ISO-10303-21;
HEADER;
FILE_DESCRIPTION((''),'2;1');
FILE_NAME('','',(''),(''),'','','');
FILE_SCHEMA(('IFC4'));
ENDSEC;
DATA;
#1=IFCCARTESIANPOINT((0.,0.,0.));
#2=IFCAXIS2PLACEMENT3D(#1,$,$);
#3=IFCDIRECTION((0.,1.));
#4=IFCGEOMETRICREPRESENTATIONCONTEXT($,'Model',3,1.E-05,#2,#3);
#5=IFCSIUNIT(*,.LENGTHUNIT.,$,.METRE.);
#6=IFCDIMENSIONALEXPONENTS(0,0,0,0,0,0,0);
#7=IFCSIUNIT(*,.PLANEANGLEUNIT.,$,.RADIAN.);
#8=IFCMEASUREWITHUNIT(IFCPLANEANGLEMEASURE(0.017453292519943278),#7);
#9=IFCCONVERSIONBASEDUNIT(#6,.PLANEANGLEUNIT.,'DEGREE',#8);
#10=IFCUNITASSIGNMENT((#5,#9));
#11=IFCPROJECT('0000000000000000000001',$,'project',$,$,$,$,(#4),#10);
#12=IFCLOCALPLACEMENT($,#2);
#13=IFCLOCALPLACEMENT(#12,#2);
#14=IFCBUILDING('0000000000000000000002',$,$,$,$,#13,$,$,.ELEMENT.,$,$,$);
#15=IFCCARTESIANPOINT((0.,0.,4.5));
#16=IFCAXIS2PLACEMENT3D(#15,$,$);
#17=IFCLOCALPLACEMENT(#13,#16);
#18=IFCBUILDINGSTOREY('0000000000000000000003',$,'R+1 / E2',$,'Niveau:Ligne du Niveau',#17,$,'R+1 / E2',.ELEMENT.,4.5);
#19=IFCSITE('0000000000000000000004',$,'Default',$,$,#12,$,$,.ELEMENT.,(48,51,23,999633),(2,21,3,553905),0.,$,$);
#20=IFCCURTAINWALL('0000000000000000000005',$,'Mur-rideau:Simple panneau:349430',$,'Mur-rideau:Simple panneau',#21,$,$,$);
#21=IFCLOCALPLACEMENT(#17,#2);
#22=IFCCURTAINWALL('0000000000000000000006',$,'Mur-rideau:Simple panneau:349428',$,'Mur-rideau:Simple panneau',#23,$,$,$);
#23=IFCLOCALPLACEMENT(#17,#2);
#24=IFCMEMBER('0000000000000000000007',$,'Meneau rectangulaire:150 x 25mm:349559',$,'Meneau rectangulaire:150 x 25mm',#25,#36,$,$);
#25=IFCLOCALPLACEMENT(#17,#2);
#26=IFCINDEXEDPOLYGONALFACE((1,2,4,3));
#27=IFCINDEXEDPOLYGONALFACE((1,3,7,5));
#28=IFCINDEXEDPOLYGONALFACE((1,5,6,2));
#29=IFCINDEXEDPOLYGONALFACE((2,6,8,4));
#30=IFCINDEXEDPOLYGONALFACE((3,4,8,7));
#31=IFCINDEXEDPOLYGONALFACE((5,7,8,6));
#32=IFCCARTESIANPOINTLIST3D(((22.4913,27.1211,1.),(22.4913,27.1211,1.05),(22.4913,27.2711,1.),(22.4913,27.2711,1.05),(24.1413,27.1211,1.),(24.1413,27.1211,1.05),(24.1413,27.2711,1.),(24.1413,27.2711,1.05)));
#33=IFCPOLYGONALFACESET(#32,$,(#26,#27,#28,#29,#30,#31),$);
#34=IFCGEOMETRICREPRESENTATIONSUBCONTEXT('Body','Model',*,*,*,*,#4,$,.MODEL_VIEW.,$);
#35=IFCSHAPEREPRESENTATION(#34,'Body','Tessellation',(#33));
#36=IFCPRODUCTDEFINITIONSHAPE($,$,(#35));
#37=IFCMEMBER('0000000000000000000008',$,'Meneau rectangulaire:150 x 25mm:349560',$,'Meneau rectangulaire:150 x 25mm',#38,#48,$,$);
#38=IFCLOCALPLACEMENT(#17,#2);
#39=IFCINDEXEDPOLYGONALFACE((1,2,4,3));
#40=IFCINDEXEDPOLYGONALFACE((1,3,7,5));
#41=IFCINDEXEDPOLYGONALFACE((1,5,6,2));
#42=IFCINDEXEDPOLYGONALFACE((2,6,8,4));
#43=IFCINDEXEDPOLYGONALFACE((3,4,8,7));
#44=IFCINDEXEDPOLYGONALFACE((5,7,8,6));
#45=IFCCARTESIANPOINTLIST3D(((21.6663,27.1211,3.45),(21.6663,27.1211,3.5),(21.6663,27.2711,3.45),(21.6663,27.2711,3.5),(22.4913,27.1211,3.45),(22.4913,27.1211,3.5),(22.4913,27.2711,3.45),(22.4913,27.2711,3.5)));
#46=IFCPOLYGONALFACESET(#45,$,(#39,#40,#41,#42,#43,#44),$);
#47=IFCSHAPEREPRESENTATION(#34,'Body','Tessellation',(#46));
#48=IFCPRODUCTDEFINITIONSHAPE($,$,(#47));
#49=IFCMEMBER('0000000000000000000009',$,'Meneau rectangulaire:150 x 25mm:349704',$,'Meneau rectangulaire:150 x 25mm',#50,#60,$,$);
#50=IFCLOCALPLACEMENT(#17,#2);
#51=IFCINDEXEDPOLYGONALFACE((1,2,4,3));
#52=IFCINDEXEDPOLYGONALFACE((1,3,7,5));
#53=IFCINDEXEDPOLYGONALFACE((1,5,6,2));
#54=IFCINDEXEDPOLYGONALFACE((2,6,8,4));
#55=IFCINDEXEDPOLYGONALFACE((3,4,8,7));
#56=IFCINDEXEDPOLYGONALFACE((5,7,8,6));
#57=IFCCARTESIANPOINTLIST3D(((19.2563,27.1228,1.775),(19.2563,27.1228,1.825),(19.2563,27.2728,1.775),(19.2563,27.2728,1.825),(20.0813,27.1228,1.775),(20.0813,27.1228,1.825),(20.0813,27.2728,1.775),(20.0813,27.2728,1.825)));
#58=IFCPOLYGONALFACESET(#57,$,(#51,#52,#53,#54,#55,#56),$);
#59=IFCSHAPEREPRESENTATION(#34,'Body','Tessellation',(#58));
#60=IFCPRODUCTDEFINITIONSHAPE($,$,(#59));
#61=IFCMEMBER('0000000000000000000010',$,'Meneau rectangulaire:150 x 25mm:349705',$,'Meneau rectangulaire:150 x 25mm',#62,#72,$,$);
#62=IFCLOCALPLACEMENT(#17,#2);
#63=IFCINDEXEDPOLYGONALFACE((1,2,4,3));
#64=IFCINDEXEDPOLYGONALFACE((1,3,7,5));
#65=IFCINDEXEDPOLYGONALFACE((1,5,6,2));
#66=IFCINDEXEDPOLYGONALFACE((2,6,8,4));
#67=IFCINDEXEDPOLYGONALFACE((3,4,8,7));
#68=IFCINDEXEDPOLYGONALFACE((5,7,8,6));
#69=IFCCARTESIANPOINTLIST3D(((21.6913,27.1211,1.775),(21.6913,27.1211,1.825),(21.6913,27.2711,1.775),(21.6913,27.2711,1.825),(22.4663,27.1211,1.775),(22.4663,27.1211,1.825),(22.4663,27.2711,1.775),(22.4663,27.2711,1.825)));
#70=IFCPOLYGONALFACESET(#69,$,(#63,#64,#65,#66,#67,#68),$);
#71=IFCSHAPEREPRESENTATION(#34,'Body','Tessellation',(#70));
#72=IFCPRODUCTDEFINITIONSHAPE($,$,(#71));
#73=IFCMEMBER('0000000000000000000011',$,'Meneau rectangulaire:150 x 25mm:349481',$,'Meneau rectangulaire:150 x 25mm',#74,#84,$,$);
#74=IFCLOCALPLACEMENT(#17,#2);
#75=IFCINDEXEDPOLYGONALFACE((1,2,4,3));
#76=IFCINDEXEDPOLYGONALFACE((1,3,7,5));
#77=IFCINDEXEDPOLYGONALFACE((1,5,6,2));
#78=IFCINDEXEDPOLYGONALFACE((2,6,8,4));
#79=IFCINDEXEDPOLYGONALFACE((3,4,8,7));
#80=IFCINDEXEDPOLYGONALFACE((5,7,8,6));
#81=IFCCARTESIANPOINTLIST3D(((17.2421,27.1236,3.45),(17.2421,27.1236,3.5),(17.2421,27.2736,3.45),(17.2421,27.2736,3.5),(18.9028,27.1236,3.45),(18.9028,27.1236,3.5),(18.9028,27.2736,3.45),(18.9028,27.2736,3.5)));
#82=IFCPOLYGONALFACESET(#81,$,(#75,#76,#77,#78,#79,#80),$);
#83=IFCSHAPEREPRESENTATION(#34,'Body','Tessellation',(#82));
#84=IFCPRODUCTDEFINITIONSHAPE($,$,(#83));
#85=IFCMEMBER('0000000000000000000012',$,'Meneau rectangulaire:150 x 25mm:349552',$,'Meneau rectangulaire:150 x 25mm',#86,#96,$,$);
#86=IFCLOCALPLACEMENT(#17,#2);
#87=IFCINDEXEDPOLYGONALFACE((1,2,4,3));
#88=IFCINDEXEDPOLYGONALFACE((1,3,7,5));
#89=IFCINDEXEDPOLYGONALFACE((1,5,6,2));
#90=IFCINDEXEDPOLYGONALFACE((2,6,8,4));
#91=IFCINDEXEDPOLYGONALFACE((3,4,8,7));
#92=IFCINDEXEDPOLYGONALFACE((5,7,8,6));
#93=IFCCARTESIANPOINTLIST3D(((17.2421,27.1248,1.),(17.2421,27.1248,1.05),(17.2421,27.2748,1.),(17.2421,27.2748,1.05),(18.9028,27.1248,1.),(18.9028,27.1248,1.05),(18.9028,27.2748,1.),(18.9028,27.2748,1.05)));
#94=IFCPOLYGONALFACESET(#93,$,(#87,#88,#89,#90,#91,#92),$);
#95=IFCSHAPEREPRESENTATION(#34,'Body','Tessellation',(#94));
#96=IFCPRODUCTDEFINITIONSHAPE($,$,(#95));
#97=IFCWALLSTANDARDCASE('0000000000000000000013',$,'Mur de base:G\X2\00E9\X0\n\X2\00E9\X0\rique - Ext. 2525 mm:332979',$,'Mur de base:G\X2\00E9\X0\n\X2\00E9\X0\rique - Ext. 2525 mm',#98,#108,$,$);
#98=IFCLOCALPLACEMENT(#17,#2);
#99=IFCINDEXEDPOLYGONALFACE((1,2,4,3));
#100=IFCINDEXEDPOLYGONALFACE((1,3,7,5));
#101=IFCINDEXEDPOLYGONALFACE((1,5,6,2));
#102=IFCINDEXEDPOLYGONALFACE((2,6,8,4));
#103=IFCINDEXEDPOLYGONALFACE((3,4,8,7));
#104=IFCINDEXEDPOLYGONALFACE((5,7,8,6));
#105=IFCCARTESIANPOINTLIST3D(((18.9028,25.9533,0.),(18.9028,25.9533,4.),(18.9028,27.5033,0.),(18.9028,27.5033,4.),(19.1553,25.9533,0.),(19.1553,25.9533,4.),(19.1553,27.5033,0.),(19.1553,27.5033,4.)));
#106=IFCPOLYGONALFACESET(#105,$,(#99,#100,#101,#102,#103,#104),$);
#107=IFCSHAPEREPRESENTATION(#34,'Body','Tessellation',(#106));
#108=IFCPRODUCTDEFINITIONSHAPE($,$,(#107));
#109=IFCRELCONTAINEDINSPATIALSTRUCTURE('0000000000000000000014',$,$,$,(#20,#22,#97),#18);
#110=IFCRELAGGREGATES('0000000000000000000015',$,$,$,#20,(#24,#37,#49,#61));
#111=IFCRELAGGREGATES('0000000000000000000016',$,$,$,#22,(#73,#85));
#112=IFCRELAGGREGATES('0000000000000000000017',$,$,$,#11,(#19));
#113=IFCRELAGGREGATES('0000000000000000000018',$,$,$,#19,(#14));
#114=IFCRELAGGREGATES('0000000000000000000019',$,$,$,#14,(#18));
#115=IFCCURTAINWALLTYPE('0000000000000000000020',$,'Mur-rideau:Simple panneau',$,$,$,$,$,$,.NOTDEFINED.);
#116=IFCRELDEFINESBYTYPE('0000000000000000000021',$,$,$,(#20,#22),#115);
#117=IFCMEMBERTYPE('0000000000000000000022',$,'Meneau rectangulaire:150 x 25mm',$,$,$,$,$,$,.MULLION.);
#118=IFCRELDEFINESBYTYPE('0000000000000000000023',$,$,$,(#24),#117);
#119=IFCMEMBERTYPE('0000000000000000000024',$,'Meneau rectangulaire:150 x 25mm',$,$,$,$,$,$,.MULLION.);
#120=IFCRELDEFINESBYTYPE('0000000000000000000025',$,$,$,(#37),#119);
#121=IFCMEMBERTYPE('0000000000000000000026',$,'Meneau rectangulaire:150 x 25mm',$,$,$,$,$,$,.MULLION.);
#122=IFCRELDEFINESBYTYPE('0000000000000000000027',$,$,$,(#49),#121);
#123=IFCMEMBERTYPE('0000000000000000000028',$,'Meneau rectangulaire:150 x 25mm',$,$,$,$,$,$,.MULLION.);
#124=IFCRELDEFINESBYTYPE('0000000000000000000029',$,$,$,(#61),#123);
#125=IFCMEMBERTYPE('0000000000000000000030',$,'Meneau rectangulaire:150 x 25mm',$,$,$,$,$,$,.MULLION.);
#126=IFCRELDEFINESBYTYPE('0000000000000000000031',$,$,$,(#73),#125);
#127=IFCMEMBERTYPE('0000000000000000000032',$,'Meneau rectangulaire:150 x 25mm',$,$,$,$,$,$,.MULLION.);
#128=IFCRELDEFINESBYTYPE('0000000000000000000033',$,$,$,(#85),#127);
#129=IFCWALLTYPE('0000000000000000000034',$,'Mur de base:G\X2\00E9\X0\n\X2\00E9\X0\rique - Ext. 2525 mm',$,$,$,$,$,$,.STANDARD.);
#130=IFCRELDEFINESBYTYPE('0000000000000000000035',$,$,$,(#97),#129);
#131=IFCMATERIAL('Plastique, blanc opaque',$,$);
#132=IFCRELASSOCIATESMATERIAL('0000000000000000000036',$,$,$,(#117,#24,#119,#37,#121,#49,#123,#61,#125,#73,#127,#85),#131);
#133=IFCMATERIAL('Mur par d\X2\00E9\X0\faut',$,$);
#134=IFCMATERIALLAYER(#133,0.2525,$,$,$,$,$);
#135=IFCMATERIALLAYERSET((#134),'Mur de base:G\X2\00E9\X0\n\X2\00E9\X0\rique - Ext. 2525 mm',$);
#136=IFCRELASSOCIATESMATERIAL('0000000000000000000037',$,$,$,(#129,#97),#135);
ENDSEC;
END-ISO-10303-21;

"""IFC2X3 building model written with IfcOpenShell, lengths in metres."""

from ifc_helpers import new_model, entity, si_unit, converted_unit, direction, frame, frame_2d, origin, origin_2d_with_axis, place, context, subcontext, project, spatial, rectangle, extrude, source, transform, mapped, material, layer, layer_set, layer_usage, type_object, type_shapes, element, aggregate, save


model = new_model("IFC2X3")

# Units and contexts
model_context = context("Model", 3, precision=1e-05, world=origin(), true_north=direction((0.0, 1.0)))
body_context = subcontext(model_context, "Body", "Model", "MODEL_VIEW")
ifc_project = project(units=[si_unit("LENGTHUNIT", "METRE"), converted_unit("PLANEANGLEUNIT", "DEGREE", entity("IfcPlaneAngleMeasure", 0.017453292519943278), si_unit("PLANEANGLEUNIT", "RADIAN"), dimensions=[0, 0, 0, 0, 0, 0, 0])], contexts=[model_context])

# Site, building, storey
site_placement = place(None, origin())
site = spatial("IfcSite", under=ifc_project, at=site_placement, Name="Default", CompositionType="ELEMENT", RefLatitude=(48, 51, 23, 999633), RefLongitude=(2, 21, 3, 553905), RefElevation=0.0)
building_placement = place(site_placement, origin())
building = spatial("IfcBuilding", under=site, at=building_placement, CompositionType="ELEMENT")
storey_placement = place(building_placement, frame((0.0, 0.0, 4.5)))
storey = spatial("IfcBuildingStorey", under=building, at=storey_placement, Name="R+1 / E2", ObjectType="Niveau:Ligne du Niveau", LongName="R+1 / E2", CompositionType="ELEMENT", Elevation=4.5)

# Curtain wall
curtain_wall_type = type_object("IfcCurtainWallType", Name="Mur-rideau:Simple panneau", PredefinedType="NOTDEFINED")
curtain_wall_1_placement = place(storey_placement, frame((0.0, 0.0, -4.5)))
curtain_wall_1 = element("IfcCurtainWall", 1, at=curtain_wall_1_placement, inside=storey, type_object=curtain_wall_type, Name="Mur-rideau:Simple panneau:349430", ObjectType="Mur-rideau:Simple panneau")
ifc_material_1 = material(Name="Plastique, blanc opaque")

# Curtain wall
curtain_wall_2_placement = place(storey_placement, frame((0.0, 0.0, -4.5)))
curtain_wall_2 = element("IfcCurtainWall", 2, at=curtain_wall_2_placement, inside=storey, type_object=curtain_wall_type, Name="Mur-rideau:Simple panneau:349428", ObjectType="Mur-rideau:Simple panneau")

# Members
member_type_1 = type_object("IfcMemberType", Name="Meneau rectangulaire:150 x 25mm", PredefinedType="MULLION", material=ifc_material_1)
shared_shape_1 = source(origin(), body_context, "Body", "SweptSolid", [
    extrude(rectangle(XDim=0.05, YDim=0.15, at=origin_2d_with_axis()), frame((-0.025, 0.0, -1.65), z_axis=(0.0, 0.0, 1.0), x_axis=(-1.0, 0.0, 0.0)), (0.0, 0.0, 1.0), 1.65),
])
type_shapes(member_type_1, [shared_shape_1])
member_1_placement = place(curtain_wall_1_placement, frame((22.4913, 27.1961, 5.5), z_axis=(-1.0, 0.0, 0.0), x_axis=(0.0, 0.0, -1.0)))
member_1 = element("IfcMember", 3, at=member_1_placement, type_object=member_type_1, material=ifc_material_1, Name="Meneau rectangulaire:150 x 25mm:349559", ObjectType="Meneau rectangulaire:150 x 25mm", context=body_context, shape_type="MappedRepresentation", body=[
    mapped(shared_shape_1, transform((0.0, 0.0, 0.0), scale=1.0)),
])
member_type_2 = type_object("IfcMemberType", Name="Meneau rectangulaire:150 x 25mm", PredefinedType="MULLION", material=ifc_material_1)
shared_shape_2 = source(origin(), body_context, "Body", "SweptSolid", [
    extrude(rectangle(XDim=0.05, YDim=0.15, at=frame_2d((0.0, 0.0), x_axis=(1.0, 0.0))), frame((-0.025, 0.0, -0.825), z_axis=(0.0, 0.0, 1.0), x_axis=(-1.0, 0.0, 0.0)), (0.0, 0.0, 1.0), 0.825),
])
type_shapes(member_type_2, [shared_shape_2])
member_2_placement = place(curtain_wall_1_placement, frame((22.4913, 27.1961, 8.0), z_axis=(1.0, 0.0, 0.0), x_axis=(0.0, 0.0, 1.0)))
member_2 = element("IfcMember", 4, at=member_2_placement, type_object=member_type_2, material=ifc_material_1, Name="Meneau rectangulaire:150 x 25mm:349560", ObjectType="Meneau rectangulaire:150 x 25mm", context=body_context, shape_type="MappedRepresentation", body=[
    mapped(shared_shape_2, transform((0.0, 0.0, 0.0), scale=1.0)),
])
member_type_3 = type_object("IfcMemberType", Name="Meneau rectangulaire:150 x 25mm", PredefinedType="MULLION", material=ifc_material_1)
shared_shape_3 = source(origin(), body_context, "Body", "SweptSolid", [
    extrude(rectangle(XDim=0.05, YDim=0.15, at=frame_2d((0.0, 0.0), x_axis=(1.0, 0.0))), frame((0.0, 0.0, -0.825), z_axis=(0.0, 0.0, 1.0), x_axis=(-1.0, 0.0, 0.0)), (0.0, 0.0, 1.0), 0.825),
])
type_shapes(member_type_3, [shared_shape_3])
member_3_placement = place(curtain_wall_1_placement, frame((20.0813, 27.1978, 6.3), z_axis=(1.0, 0.0, 0.0), x_axis=(0.0, 0.0, 1.0)))
member_3 = element("IfcMember", 5, at=member_3_placement, type_object=member_type_3, material=ifc_material_1, Name="Meneau rectangulaire:150 x 25mm:349704", ObjectType="Meneau rectangulaire:150 x 25mm", context=body_context, shape_type="MappedRepresentation", body=[
    mapped(shared_shape_3, transform((0.0, 0.0, 0.0), scale=1.0)),
])
member_type_4 = type_object("IfcMemberType", Name="Meneau rectangulaire:150 x 25mm", PredefinedType="MULLION", material=ifc_material_1)
shared_shape_4 = source(origin(), body_context, "Body", "SweptSolid", [
    extrude(rectangle(XDim=0.05, YDim=0.15, at=frame_2d((0.0, 0.0), x_axis=(1.0, 0.0))), frame((0.0, 0.0, -0.775), z_axis=(0.0, 0.0, 1.0), x_axis=(-1.0, 0.0, 0.0)), (0.0, 0.0, 1.0), 0.775),
])
type_shapes(member_type_4, [shared_shape_4])
member_4_placement = place(curtain_wall_1_placement, frame((22.4663, 27.1961, 6.3), z_axis=(1.0, 0.0, 0.0), x_axis=(0.0, 0.0, 1.0)))
member_4 = element("IfcMember", 6, at=member_4_placement, type_object=member_type_4, material=ifc_material_1, Name="Meneau rectangulaire:150 x 25mm:349705", ObjectType="Meneau rectangulaire:150 x 25mm", context=body_context, shape_type="MappedRepresentation", body=[
    mapped(shared_shape_4, transform((0.0, 0.0, 0.0), scale=1.0)),
])
member_type_5 = type_object("IfcMemberType", Name="Meneau rectangulaire:150 x 25mm", PredefinedType="MULLION", material=ifc_material_1)
shared_shape_5 = source(origin(), body_context, "Body", "SweptSolid", [
    extrude(rectangle(XDim=0.05, YDim=0.15, at=origin_2d_with_axis()), frame((-0.025, 0.0, -1.6607), z_axis=(0.0, 0.0, 1.0), x_axis=(-1.0, 0.0, 0.0)), (0.0, 0.0, 1.0), 1.6607),
])
type_shapes(member_type_5, [shared_shape_5])
member_5_placement = place(curtain_wall_2_placement, frame((18.9028, 27.1986, 8.0), z_axis=(1.0, 0.0, 0.0), x_axis=(0.0, 0.0, 1.0)))
member_5 = element("IfcMember", 7, at=member_5_placement, type_object=member_type_5, material=ifc_material_1, Name="Meneau rectangulaire:150 x 25mm:349481", ObjectType="Meneau rectangulaire:150 x 25mm", context=body_context, shape_type="MappedRepresentation", body=[
    mapped(shared_shape_5, transform((0.0, 0.0, 0.0), scale=1.0)),
])
member_type_6 = type_object("IfcMemberType", Name="Meneau rectangulaire:150 x 25mm", PredefinedType="MULLION", material=ifc_material_1)
shared_shape_6 = source(origin(), body_context, "Body", "SweptSolid", [
    extrude(rectangle(XDim=0.05, YDim=0.15, at=origin_2d_with_axis()), frame((-0.025, 0.0, -1.6607), z_axis=(0.0, 0.0, 1.0), x_axis=(-1.0, 0.0, 0.0)), (0.0, 0.0, 1.0), 1.6607),
])
type_shapes(member_type_6, [shared_shape_6])
member_6_placement = place(curtain_wall_2_placement, frame((17.2421, 27.1998, 5.5), z_axis=(-1.0, 0.0, 0.0), x_axis=(0.0, 0.0, -1.0)))
member_6 = element("IfcMember", 8, at=member_6_placement, type_object=member_type_6, material=ifc_material_1, Name="Meneau rectangulaire:150 x 25mm:349552", ObjectType="Meneau rectangulaire:150 x 25mm", context=body_context, shape_type="MappedRepresentation", body=[
    mapped(shared_shape_6, transform((0.0, 0.0, 0.0), scale=1.0)),
])

aggregate(curtain_wall_1, [member_1, member_2, member_3, member_4])
aggregate(curtain_wall_2, [member_5, member_6])

# Wall
ifc_material_2 = material(Name="Mur par défaut")
ifc_layer_1 = layer(ifc_material_2, 0.2525)
ifc_layer_set_1 = layer_set([ifc_layer_1], Name="Mur de base:Générique - Ext. 2525 mm")
ifc_layer_usage = layer_usage(ifc_layer_set_1, "AXIS2", "NEGATIVE", 0.1263)
wall_type = type_object("IfcWallType", Name="Mur de base:Générique - Ext. 2525 mm", PredefinedType="STANDARD", material=ifc_layer_set_1)
wall_placement = place(storey_placement, frame((19.0291, 25.9533, 0.0), z_axis=(0.0, 0.0, 1.0), x_axis=(0.0, 1.0, 0.0)))
element("IfcWallStandardCase", 9, at=wall_placement, inside=storey, type_object=wall_type, material=ifc_layer_usage, Name="Mur de base:Générique - Ext. 2525 mm:332979", ObjectType="Mur de base:Générique - Ext. 2525 mm", context=body_context, shape_type="SweptSolid", body=[
    extrude(rectangle(XDim=1.55, YDim=0.2525, at=frame_2d((0.775, 0.0), x_axis=(-1.0, 0.0))), origin(), (0.0, 0.0, 1.0), 4.0),
])

save(model, "model.ifc")
